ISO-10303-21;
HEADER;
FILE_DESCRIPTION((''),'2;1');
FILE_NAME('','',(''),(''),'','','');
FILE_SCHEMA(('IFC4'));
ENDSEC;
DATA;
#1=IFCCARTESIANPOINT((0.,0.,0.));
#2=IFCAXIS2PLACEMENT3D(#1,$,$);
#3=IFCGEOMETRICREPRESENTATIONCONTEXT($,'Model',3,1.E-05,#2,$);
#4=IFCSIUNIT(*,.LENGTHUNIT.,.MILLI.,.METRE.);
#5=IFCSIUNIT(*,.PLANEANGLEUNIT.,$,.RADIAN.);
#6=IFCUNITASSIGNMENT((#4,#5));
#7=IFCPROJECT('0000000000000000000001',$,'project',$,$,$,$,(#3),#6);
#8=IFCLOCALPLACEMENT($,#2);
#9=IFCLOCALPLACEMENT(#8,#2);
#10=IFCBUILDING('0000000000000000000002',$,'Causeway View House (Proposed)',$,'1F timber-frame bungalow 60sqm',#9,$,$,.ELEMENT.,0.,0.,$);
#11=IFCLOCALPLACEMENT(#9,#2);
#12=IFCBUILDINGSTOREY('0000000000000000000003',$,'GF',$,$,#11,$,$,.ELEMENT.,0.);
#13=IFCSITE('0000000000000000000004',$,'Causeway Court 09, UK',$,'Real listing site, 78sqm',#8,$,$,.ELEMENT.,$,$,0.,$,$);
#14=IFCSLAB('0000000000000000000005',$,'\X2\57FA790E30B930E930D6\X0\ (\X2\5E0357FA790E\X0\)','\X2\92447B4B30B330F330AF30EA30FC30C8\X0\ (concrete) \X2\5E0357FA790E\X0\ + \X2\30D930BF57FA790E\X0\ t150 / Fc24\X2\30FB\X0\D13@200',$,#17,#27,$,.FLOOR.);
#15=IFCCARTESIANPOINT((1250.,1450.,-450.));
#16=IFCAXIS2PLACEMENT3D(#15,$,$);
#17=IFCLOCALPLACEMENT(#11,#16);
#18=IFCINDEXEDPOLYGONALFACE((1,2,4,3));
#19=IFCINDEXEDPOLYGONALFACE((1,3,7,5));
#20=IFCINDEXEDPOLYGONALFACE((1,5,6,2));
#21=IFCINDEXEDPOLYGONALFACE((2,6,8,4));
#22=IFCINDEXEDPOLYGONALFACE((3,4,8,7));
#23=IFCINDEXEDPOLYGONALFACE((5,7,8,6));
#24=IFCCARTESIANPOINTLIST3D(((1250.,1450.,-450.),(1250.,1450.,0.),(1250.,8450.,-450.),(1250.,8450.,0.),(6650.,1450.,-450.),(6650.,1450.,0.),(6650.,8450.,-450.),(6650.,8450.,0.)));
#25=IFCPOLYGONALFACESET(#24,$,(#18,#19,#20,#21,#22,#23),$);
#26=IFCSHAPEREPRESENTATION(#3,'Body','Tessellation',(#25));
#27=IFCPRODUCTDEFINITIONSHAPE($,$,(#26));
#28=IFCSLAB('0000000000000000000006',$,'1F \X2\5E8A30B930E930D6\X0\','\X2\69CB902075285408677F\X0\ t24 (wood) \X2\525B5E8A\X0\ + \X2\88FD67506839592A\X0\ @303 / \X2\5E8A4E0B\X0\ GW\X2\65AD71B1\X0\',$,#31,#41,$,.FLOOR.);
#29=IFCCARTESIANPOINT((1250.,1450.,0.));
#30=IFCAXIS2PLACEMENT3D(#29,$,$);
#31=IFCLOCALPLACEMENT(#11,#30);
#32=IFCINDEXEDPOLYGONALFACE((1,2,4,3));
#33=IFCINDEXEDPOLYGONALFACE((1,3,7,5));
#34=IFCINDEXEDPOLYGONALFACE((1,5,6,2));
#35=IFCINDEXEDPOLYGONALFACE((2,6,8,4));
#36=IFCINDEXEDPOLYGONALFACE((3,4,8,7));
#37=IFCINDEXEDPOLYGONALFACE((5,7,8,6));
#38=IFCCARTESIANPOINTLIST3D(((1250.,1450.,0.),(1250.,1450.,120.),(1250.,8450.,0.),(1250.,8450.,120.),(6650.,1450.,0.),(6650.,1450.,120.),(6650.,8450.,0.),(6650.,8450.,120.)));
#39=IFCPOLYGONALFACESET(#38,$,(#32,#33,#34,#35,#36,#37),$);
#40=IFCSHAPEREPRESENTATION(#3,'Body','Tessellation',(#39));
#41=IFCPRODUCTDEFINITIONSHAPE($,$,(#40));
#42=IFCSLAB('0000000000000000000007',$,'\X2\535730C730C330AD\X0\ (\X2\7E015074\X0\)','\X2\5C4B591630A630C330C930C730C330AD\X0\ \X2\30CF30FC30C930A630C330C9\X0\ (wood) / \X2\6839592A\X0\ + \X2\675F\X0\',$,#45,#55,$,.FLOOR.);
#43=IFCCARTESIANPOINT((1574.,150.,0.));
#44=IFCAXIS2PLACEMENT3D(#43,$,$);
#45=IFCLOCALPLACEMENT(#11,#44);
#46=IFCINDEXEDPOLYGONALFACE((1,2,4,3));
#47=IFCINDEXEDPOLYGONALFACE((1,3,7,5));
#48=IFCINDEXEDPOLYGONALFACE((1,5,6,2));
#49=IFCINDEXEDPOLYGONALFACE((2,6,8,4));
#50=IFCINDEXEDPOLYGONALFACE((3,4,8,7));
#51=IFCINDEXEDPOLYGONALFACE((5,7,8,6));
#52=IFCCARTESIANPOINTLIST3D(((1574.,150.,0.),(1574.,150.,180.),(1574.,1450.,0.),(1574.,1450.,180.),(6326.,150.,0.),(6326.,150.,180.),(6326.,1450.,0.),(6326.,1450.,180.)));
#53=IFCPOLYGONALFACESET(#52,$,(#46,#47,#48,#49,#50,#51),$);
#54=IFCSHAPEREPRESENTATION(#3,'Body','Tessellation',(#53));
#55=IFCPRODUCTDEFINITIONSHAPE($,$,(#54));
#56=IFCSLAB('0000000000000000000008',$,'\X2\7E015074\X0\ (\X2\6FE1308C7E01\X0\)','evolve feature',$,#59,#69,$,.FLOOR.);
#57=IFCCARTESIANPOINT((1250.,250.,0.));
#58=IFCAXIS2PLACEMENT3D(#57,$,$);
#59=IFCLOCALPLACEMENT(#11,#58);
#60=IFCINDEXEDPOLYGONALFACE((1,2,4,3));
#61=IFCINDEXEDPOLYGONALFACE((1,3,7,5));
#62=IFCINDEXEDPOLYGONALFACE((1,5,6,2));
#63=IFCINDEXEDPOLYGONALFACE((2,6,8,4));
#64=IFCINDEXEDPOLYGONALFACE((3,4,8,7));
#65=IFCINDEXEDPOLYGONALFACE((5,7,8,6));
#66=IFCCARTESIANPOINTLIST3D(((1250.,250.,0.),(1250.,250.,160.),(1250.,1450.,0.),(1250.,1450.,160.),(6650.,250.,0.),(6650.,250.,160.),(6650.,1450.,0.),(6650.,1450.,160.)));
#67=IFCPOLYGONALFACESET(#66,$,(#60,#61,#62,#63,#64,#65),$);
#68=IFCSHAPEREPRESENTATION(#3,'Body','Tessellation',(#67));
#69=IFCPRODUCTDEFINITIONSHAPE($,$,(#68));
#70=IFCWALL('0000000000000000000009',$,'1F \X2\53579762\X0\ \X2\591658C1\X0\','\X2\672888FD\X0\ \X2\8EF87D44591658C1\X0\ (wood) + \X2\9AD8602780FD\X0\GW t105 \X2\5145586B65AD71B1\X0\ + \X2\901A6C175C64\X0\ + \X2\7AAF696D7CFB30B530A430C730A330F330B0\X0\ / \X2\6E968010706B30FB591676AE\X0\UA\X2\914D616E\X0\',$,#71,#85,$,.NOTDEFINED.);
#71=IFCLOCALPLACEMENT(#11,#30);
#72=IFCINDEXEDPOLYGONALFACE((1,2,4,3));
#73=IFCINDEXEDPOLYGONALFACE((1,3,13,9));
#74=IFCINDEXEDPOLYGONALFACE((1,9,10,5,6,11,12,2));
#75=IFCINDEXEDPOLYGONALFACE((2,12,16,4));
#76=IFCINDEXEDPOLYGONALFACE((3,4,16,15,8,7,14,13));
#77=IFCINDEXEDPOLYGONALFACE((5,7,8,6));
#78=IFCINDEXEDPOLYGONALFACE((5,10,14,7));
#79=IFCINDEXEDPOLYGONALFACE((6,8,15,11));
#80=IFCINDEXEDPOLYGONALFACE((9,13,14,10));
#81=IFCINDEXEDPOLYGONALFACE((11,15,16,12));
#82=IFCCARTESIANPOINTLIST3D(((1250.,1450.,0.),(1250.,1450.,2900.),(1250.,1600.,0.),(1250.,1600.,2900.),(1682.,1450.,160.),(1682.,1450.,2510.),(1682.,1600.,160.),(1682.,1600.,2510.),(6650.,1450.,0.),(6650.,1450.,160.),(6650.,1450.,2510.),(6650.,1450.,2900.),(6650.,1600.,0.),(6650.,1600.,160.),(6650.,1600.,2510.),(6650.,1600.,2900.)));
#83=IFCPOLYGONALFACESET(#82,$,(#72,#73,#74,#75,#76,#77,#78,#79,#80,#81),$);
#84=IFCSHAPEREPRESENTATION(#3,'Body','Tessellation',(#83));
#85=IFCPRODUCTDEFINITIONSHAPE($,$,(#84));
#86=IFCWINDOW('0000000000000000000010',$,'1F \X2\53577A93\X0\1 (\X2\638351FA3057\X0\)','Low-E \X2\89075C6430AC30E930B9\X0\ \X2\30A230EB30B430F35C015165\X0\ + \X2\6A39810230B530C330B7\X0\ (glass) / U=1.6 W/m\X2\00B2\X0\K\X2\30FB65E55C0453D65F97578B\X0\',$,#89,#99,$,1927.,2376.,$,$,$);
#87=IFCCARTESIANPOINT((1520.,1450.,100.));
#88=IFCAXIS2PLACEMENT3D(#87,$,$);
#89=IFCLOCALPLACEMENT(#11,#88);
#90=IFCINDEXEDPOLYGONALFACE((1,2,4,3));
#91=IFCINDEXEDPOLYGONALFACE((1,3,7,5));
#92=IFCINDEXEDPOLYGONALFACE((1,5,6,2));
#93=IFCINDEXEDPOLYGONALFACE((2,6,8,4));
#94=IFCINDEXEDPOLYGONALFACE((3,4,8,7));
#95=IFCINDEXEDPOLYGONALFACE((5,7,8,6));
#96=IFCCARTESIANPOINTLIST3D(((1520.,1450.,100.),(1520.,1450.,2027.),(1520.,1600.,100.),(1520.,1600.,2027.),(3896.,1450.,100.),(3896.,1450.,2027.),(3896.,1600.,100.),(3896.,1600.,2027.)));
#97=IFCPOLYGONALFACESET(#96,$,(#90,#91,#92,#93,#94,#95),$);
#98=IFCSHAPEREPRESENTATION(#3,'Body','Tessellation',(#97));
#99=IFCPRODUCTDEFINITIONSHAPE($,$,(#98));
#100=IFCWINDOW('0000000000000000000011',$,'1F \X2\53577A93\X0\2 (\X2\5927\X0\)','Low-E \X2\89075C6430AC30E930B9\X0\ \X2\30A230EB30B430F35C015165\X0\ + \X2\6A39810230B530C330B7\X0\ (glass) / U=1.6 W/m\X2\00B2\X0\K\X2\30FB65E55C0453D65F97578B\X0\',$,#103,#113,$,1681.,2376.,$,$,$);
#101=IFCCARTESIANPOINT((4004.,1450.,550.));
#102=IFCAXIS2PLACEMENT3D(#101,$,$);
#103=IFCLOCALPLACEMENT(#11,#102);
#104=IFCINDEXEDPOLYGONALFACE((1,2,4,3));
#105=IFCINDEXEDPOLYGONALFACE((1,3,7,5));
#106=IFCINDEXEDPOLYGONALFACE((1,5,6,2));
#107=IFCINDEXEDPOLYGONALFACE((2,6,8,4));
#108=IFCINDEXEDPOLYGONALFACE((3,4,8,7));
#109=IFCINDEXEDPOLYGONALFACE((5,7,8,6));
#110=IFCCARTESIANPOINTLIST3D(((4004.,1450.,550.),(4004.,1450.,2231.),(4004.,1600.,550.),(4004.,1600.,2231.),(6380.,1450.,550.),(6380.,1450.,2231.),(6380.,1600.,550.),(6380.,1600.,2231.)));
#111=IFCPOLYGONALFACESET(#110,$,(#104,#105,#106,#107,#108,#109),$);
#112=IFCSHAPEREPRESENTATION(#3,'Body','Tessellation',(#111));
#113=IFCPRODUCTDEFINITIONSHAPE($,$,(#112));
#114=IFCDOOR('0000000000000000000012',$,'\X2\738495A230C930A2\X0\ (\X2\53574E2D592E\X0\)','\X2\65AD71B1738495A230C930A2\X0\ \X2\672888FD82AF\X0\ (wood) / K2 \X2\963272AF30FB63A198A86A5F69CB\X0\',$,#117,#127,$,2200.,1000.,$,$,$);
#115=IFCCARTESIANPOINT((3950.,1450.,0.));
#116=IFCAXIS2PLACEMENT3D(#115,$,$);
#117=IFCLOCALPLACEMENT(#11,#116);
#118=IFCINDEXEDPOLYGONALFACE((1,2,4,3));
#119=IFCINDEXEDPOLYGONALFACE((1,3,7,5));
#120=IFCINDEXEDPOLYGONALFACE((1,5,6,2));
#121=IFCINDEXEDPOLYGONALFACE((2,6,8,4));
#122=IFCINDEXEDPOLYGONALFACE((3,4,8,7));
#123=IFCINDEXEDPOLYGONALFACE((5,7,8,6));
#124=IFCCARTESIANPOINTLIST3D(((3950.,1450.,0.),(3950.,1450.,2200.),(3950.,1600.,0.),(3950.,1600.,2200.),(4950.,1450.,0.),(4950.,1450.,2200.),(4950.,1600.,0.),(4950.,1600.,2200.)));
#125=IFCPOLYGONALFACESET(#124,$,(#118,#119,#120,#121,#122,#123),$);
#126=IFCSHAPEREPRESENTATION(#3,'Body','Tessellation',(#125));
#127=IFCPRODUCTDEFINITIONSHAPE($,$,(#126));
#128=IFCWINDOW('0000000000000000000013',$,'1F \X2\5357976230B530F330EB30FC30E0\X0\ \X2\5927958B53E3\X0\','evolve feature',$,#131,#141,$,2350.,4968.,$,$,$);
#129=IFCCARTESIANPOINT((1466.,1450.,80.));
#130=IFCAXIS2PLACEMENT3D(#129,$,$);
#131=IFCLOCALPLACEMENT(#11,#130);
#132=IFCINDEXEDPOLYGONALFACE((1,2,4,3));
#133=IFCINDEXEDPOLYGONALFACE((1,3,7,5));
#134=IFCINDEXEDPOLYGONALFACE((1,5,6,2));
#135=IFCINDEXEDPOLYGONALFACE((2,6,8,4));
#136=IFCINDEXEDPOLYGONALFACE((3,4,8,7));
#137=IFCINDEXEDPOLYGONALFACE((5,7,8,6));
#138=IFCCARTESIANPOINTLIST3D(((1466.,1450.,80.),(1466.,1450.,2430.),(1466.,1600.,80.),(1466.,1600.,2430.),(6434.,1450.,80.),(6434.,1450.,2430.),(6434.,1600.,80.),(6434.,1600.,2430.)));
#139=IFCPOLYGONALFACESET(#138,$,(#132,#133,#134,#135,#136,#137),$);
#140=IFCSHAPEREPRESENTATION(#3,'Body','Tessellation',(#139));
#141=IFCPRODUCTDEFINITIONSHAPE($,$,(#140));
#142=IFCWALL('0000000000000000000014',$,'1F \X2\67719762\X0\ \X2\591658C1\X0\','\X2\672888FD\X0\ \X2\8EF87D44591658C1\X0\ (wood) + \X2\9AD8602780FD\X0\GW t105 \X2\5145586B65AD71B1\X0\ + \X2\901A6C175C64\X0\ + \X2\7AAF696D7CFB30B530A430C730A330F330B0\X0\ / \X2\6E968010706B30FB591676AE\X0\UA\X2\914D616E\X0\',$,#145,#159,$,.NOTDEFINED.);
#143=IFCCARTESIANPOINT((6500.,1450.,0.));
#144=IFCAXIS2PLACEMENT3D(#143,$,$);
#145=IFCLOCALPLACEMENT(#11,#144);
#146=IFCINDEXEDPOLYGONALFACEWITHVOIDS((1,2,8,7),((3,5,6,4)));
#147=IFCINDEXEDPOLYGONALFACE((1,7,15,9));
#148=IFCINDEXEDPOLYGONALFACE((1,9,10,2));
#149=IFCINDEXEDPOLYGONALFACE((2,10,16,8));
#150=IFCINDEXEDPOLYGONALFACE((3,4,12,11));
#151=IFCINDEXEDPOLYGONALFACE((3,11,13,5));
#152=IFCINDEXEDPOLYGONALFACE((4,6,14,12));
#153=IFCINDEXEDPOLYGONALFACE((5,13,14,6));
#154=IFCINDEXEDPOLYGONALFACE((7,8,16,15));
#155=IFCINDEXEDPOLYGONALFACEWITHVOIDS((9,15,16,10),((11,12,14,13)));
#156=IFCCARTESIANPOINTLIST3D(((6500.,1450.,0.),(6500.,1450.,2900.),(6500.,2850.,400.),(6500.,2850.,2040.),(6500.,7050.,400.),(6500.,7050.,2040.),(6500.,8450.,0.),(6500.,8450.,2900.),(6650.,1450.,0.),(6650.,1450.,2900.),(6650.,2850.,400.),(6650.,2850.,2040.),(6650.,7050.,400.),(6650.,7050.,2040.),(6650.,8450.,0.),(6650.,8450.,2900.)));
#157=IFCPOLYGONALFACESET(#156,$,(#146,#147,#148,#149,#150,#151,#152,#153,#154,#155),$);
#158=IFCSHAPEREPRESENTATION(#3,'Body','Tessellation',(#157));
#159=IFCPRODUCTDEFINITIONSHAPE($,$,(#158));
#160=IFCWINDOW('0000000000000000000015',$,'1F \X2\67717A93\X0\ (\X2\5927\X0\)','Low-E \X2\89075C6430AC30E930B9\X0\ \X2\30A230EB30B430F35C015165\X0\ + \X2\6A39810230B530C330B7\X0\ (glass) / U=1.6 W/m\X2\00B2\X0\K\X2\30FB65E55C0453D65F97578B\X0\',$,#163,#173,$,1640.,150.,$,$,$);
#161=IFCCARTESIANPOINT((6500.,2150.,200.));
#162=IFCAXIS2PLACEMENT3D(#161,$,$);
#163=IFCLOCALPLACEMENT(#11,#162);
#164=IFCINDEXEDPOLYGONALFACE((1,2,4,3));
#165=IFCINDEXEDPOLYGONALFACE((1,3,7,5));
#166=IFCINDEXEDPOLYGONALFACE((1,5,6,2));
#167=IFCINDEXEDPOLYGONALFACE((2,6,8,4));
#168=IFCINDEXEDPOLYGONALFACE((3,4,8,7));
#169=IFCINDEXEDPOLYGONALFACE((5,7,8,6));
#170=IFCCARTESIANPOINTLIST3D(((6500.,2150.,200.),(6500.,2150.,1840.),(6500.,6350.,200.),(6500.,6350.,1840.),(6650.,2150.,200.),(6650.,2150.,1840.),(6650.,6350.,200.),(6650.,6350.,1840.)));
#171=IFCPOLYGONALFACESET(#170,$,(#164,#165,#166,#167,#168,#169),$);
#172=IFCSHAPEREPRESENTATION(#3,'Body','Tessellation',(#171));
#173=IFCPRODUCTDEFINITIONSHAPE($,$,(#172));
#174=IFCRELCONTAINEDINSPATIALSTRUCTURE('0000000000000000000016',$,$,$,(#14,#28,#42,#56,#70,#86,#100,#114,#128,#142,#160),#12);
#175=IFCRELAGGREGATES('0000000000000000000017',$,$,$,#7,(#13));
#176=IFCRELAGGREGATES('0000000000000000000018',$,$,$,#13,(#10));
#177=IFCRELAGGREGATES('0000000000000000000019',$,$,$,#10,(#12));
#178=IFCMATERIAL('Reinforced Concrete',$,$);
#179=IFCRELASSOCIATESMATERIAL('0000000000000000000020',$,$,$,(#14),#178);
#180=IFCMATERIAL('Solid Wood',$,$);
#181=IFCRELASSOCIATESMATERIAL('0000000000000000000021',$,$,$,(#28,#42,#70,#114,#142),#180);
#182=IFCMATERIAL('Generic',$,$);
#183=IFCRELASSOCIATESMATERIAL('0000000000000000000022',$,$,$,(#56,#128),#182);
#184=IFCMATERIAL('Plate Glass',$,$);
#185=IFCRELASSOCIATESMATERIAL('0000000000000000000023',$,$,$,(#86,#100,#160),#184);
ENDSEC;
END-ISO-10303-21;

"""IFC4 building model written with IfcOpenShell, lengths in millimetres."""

from ifc_helpers import new_model, si_unit, frame, frame_2d, origin, place, context, project, spatial, rectangle, extrude, material, element, fill, save


model = new_model("IFC4")

# Units and contexts
model_context = context("Model", 3, precision=1e-05, world=origin())
ifc_project = project(units=[si_unit("LENGTHUNIT", "METRE", prefix="MILLI"), si_unit("PLANEANGLEUNIT", "RADIAN")], contexts=[model_context])

# Site, building, storey
site_placement = place(None, origin())
site = spatial("IfcSite", under=ifc_project, at=site_placement, Name="Causeway Court 09, UK", ObjectType="Real listing site, 78sqm", CompositionType="ELEMENT", RefElevation=0.0)
building_placement = place(site_placement, origin())
building = spatial("IfcBuilding", under=site, at=building_placement, Name="Causeway View House (Proposed)", ObjectType="1F timber-frame bungalow 60sqm", CompositionType="ELEMENT", ElevationOfRefHeight=0.0, ElevationOfTerrain=0.0)
storey_placement = place(building_placement, origin())
storey = spatial("IfcBuildingStorey", under=building, at=storey_placement, Name="GF", CompositionType="ELEMENT", Elevation=0.0)

# Slabs
ifc_material_1 = material(Name="Reinforced Concrete")
slab_1_placement = place(storey_placement, frame((1250.0, 1450.0, -450.0)))
element("IfcSlab", 1, at=slab_1_placement, inside=storey, material=ifc_material_1, Name="基礎スラブ (布基礎)", Description="鉄筋コンクリート (concrete) 布基礎 + ベタ基礎 t150 / Fc24・D13@200", PredefinedType="FLOOR", context=model_context, shape_type="SweptSolid", body=[
    extrude(rectangle(XDim=5400.0, YDim=7000.0, at=frame_2d((2700.0, 3500.0))), frame((1250.0, 1450.0, -450.0)), (0.0, 0.0, 1.0), 450.0),
])
ifc_material_2 = material(Name="Solid Wood")
slab_2_placement = place(storey_placement, frame((1250.0, 1450.0, 0.0)))
element("IfcSlab", 2, at=slab_2_placement, inside=storey, material=ifc_material_2, Name="1F 床スラブ", Description="構造用合板 t24 (wood) 剛床 + 製材根太 @303 / 床下 GW断熱", PredefinedType="FLOOR", context=model_context, shape_type="SweptSolid", body=[
    extrude(rectangle(XDim=5400.0, YDim=7000.0, at=frame_2d((2700.0, 3500.0))), frame((1250.0, 1450.0, 0.0)), (0.0, 0.0, 1.0), 120.0),
])
slab_3_placement = place(storey_placement, frame((1574.0, 150.0, 0.0)))
element("IfcSlab", 3, at=slab_3_placement, inside=storey, material=ifc_material_2, Name="南デッキ (縁側)", Description="屋外ウッドデッキ ハードウッド (wood) / 根太 + 束", PredefinedType="FLOOR", context=model_context, shape_type="SweptSolid", body=[
    extrude(rectangle(XDim=4752.0, YDim=1300.0, at=frame_2d((2376.0, 650.0))), frame((1574.0, 150.0, 0.0)), (0.0, 0.0, 1.0), 180.0),
])
ifc_material_3 = material(Name="Generic")
slab_4_placement = place(storey_placement, frame((1250.0, 250.0, 0.0)))
element("IfcSlab", 4, at=slab_4_placement, inside=storey, material=ifc_material_3, Name="縁側 (濡れ縁)", Description="evolve feature", PredefinedType="FLOOR", context=model_context, shape_type="SweptSolid", body=[
    extrude(rectangle(XDim=5400.0, YDim=1200.0, at=frame_2d((2700.0, 600.0))), frame((1250.0, 250.0, 0.0)), (0.0, 0.0, 1.0), 160.0),
])

# Wall, openings, windows, door
wall_1_placement = place(storey_placement, frame((1250.0, 1450.0, 0.0)))
wall_1 = element("IfcWall", 5, at=wall_1_placement, inside=storey, material=ifc_material_2, Name="1F 南面 外壁", Description="木製 軸組外壁 (wood) + 高性能GW t105 充填断熱 + 通気層 + 窯業系サイディング / 準耐火・外皮UA配慮", PredefinedType="NOTDEFINED", context=model_context, shape_type="SweptSolid", body=[
    extrude(rectangle(XDim=5400.0, YDim=150.0, at=frame_2d((2700.0, 75.0))), frame((1250.0, 1450.0, 0.0)), (0.0, 0.0, 1.0), 2900.0),
])
opening_1_placement = place(storey_placement, frame((1520.0, 1450.0, 100.0)))
opening_1 = element("IfcOpeningElement", 6, at=opening_1_placement, cuts=wall_1, PredefinedType="NOTDEFINED", context=model_context, shape_type="SweptSolid", body=[
    extrude(rectangle(XDim=2376.0, YDim=150.0, at=frame_2d((1188.0, 75.0))), frame((1520.0, 1450.0, 100.0)), (0.0, 0.0, 1.0), 1927.0),
])
opening_2_placement = place(storey_placement, frame((4004.0, 1450.0, 550.0)))
opening_2 = element("IfcOpeningElement", 7, at=opening_2_placement, cuts=wall_1, PredefinedType="NOTDEFINED", context=model_context, shape_type="SweptSolid", body=[
    extrude(rectangle(XDim=2376.0, YDim=150.0, at=frame_2d((1188.0, 75.0))), frame((4004.0, 1450.0, 550.0)), (0.0, 0.0, 1.0), 1681.0),
])
opening_3_placement = place(storey_placement, frame((3950.0, 1450.0, 0.0)))
opening_3 = element("IfcOpeningElement", 8, at=opening_3_placement, cuts=wall_1, PredefinedType="NOTDEFINED", context=model_context, shape_type="SweptSolid", body=[
    extrude(rectangle(XDim=1000.0, YDim=150.0, at=frame_2d((500.0, 75.0))), frame((3950.0, 1450.0, 0.0)), (0.0, 0.0, 1.0), 2200.0),
])
opening_4_placement = place(storey_placement, frame((1466.0, 1450.0, 80.0)))
opening_4 = element("IfcOpeningElement", 9, at=opening_4_placement, cuts=wall_1, PredefinedType="NOTDEFINED", context=model_context, shape_type="SweptSolid", body=[
    extrude(rectangle(XDim=4968.0, YDim=150.0, at=frame_2d((2484.0, 75.0))), frame((1466.0, 1450.0, 80.0)), (0.0, 0.0, 1.0), 2350.0),
])
ifc_material_4 = material(Name="Plate Glass")
window_1_placement = place(storey_placement, frame((1520.0, 1450.0, 100.0)))
window_1 = element("IfcWindow", 10, at=window_1_placement, inside=storey, material=ifc_material_4, Name="1F 南窓1 (掃出し)", Description="Low-E 複層ガラス アルゴン封入 + 樹脂サッシ (glass) / U=1.6 W/m²K・日射取得型", OverallHeight=1927.0, OverallWidth=2376.0, context=model_context, shape_type="SweptSolid", body=[
    extrude(rectangle(XDim=2376.0, YDim=150.0, at=frame_2d((1188.0, 75.0))), frame((1520.0, 1450.0, 100.0)), (0.0, 0.0, 1.0), 1927.0),
])
fill(opening_1, window_1)
window_2_placement = place(storey_placement, frame((4004.0, 1450.0, 550.0)))
window_2 = element("IfcWindow", 11, at=window_2_placement, inside=storey, material=ifc_material_4, Name="1F 南窓2 (大)", Description="Low-E 複層ガラス アルゴン封入 + 樹脂サッシ (glass) / U=1.6 W/m²K・日射取得型", OverallHeight=1681.0, OverallWidth=2376.0, context=model_context, shape_type="SweptSolid", body=[
    extrude(rectangle(XDim=2376.0, YDim=150.0, at=frame_2d((1188.0, 75.0))), frame((4004.0, 1450.0, 550.0)), (0.0, 0.0, 1.0), 1681.0),
])
fill(opening_2, window_2)
door_placement = place(storey_placement, frame((3950.0, 1450.0, 0.0)))
door = element("IfcDoor", 12, at=door_placement, inside=storey, material=ifc_material_2, Name="玄関ドア (南中央)", Description="断熱玄関ドア 木製芯 (wood) / K2 防犯・採風機構", OverallHeight=2200.0, OverallWidth=1000.0, context=model_context, shape_type="SweptSolid", body=[
    extrude(rectangle(XDim=1000.0, YDim=150.0, at=frame_2d((500.0, 75.0))), frame((3950.0, 1450.0, 0.0)), (0.0, 0.0, 1.0), 2200.0),
])
fill(opening_3, door)
window_3_placement = place(storey_placement, frame((1466.0, 1450.0, 80.0)))
window_3 = element("IfcWindow", 13, at=window_3_placement, inside=storey, material=ifc_material_3, Name="1F 南面サンルーム 大開口", Description="evolve feature", OverallHeight=2350.0, OverallWidth=4968.0, context=model_context, shape_type="SweptSolid", body=[
    extrude(rectangle(XDim=4968.0, YDim=150.0, at=frame_2d((2484.0, 75.0))), frame((1466.0, 1450.0, 80.0)), (0.0, 0.0, 1.0), 2350.0),
])
fill(opening_4, window_3)

# Wall, opening, window
wall_2_placement = place(storey_placement, frame((6500.0, 1450.0, 0.0)))
wall_2 = element("IfcWall", 14, at=wall_2_placement, inside=storey, material=ifc_material_2, Name="1F 東面 外壁", Description="木製 軸組外壁 (wood) + 高性能GW t105 充填断熱 + 通気層 + 窯業系サイディング / 準耐火・外皮UA配慮", PredefinedType="NOTDEFINED", context=model_context, shape_type="SweptSolid", body=[
    extrude(rectangle(XDim=150.0, YDim=7000.0, at=frame_2d((75.0, 3500.0))), frame((6500.0, 1450.0, 0.0)), (0.0, 0.0, 1.0), 2900.0),
])
opening_5_placement = place(storey_placement, frame((6500.0, 2150.0, 200.0)))
opening_5 = element("IfcOpeningElement", 15, at=opening_5_placement, cuts=wall_2, PredefinedType="NOTDEFINED", context=model_context, shape_type="SweptSolid", body=[
    extrude(rectangle(XDim=150.0, YDim=4200.0, at=frame_2d((75.0, 2100.0))), frame((6500.0, 2150.0, 200.0)), (0.0, 0.0, 1.0), 1640.0),
])
window_4_placement = place(storey_placement, frame((6500.0, 2150.0, 200.0)))
window_4 = element("IfcWindow", 16, at=window_4_placement, inside=storey, material=ifc_material_4, Name="1F 東窓 (大)", Description="Low-E 複層ガラス アルゴン封入 + 樹脂サッシ (glass) / U=1.6 W/m²K・日射取得型", OverallHeight=1640.0, OverallWidth=150.0, context=model_context, shape_type="SweptSolid", body=[
    extrude(rectangle(XDim=150.0, YDim=4200.0, at=frame_2d((75.0, 2100.0))), frame((6500.0, 2150.0, 200.0)), (0.0, 0.0, 1.0), 1640.0),
])
fill(opening_5, window_4)

save(model, "model.ifc")
